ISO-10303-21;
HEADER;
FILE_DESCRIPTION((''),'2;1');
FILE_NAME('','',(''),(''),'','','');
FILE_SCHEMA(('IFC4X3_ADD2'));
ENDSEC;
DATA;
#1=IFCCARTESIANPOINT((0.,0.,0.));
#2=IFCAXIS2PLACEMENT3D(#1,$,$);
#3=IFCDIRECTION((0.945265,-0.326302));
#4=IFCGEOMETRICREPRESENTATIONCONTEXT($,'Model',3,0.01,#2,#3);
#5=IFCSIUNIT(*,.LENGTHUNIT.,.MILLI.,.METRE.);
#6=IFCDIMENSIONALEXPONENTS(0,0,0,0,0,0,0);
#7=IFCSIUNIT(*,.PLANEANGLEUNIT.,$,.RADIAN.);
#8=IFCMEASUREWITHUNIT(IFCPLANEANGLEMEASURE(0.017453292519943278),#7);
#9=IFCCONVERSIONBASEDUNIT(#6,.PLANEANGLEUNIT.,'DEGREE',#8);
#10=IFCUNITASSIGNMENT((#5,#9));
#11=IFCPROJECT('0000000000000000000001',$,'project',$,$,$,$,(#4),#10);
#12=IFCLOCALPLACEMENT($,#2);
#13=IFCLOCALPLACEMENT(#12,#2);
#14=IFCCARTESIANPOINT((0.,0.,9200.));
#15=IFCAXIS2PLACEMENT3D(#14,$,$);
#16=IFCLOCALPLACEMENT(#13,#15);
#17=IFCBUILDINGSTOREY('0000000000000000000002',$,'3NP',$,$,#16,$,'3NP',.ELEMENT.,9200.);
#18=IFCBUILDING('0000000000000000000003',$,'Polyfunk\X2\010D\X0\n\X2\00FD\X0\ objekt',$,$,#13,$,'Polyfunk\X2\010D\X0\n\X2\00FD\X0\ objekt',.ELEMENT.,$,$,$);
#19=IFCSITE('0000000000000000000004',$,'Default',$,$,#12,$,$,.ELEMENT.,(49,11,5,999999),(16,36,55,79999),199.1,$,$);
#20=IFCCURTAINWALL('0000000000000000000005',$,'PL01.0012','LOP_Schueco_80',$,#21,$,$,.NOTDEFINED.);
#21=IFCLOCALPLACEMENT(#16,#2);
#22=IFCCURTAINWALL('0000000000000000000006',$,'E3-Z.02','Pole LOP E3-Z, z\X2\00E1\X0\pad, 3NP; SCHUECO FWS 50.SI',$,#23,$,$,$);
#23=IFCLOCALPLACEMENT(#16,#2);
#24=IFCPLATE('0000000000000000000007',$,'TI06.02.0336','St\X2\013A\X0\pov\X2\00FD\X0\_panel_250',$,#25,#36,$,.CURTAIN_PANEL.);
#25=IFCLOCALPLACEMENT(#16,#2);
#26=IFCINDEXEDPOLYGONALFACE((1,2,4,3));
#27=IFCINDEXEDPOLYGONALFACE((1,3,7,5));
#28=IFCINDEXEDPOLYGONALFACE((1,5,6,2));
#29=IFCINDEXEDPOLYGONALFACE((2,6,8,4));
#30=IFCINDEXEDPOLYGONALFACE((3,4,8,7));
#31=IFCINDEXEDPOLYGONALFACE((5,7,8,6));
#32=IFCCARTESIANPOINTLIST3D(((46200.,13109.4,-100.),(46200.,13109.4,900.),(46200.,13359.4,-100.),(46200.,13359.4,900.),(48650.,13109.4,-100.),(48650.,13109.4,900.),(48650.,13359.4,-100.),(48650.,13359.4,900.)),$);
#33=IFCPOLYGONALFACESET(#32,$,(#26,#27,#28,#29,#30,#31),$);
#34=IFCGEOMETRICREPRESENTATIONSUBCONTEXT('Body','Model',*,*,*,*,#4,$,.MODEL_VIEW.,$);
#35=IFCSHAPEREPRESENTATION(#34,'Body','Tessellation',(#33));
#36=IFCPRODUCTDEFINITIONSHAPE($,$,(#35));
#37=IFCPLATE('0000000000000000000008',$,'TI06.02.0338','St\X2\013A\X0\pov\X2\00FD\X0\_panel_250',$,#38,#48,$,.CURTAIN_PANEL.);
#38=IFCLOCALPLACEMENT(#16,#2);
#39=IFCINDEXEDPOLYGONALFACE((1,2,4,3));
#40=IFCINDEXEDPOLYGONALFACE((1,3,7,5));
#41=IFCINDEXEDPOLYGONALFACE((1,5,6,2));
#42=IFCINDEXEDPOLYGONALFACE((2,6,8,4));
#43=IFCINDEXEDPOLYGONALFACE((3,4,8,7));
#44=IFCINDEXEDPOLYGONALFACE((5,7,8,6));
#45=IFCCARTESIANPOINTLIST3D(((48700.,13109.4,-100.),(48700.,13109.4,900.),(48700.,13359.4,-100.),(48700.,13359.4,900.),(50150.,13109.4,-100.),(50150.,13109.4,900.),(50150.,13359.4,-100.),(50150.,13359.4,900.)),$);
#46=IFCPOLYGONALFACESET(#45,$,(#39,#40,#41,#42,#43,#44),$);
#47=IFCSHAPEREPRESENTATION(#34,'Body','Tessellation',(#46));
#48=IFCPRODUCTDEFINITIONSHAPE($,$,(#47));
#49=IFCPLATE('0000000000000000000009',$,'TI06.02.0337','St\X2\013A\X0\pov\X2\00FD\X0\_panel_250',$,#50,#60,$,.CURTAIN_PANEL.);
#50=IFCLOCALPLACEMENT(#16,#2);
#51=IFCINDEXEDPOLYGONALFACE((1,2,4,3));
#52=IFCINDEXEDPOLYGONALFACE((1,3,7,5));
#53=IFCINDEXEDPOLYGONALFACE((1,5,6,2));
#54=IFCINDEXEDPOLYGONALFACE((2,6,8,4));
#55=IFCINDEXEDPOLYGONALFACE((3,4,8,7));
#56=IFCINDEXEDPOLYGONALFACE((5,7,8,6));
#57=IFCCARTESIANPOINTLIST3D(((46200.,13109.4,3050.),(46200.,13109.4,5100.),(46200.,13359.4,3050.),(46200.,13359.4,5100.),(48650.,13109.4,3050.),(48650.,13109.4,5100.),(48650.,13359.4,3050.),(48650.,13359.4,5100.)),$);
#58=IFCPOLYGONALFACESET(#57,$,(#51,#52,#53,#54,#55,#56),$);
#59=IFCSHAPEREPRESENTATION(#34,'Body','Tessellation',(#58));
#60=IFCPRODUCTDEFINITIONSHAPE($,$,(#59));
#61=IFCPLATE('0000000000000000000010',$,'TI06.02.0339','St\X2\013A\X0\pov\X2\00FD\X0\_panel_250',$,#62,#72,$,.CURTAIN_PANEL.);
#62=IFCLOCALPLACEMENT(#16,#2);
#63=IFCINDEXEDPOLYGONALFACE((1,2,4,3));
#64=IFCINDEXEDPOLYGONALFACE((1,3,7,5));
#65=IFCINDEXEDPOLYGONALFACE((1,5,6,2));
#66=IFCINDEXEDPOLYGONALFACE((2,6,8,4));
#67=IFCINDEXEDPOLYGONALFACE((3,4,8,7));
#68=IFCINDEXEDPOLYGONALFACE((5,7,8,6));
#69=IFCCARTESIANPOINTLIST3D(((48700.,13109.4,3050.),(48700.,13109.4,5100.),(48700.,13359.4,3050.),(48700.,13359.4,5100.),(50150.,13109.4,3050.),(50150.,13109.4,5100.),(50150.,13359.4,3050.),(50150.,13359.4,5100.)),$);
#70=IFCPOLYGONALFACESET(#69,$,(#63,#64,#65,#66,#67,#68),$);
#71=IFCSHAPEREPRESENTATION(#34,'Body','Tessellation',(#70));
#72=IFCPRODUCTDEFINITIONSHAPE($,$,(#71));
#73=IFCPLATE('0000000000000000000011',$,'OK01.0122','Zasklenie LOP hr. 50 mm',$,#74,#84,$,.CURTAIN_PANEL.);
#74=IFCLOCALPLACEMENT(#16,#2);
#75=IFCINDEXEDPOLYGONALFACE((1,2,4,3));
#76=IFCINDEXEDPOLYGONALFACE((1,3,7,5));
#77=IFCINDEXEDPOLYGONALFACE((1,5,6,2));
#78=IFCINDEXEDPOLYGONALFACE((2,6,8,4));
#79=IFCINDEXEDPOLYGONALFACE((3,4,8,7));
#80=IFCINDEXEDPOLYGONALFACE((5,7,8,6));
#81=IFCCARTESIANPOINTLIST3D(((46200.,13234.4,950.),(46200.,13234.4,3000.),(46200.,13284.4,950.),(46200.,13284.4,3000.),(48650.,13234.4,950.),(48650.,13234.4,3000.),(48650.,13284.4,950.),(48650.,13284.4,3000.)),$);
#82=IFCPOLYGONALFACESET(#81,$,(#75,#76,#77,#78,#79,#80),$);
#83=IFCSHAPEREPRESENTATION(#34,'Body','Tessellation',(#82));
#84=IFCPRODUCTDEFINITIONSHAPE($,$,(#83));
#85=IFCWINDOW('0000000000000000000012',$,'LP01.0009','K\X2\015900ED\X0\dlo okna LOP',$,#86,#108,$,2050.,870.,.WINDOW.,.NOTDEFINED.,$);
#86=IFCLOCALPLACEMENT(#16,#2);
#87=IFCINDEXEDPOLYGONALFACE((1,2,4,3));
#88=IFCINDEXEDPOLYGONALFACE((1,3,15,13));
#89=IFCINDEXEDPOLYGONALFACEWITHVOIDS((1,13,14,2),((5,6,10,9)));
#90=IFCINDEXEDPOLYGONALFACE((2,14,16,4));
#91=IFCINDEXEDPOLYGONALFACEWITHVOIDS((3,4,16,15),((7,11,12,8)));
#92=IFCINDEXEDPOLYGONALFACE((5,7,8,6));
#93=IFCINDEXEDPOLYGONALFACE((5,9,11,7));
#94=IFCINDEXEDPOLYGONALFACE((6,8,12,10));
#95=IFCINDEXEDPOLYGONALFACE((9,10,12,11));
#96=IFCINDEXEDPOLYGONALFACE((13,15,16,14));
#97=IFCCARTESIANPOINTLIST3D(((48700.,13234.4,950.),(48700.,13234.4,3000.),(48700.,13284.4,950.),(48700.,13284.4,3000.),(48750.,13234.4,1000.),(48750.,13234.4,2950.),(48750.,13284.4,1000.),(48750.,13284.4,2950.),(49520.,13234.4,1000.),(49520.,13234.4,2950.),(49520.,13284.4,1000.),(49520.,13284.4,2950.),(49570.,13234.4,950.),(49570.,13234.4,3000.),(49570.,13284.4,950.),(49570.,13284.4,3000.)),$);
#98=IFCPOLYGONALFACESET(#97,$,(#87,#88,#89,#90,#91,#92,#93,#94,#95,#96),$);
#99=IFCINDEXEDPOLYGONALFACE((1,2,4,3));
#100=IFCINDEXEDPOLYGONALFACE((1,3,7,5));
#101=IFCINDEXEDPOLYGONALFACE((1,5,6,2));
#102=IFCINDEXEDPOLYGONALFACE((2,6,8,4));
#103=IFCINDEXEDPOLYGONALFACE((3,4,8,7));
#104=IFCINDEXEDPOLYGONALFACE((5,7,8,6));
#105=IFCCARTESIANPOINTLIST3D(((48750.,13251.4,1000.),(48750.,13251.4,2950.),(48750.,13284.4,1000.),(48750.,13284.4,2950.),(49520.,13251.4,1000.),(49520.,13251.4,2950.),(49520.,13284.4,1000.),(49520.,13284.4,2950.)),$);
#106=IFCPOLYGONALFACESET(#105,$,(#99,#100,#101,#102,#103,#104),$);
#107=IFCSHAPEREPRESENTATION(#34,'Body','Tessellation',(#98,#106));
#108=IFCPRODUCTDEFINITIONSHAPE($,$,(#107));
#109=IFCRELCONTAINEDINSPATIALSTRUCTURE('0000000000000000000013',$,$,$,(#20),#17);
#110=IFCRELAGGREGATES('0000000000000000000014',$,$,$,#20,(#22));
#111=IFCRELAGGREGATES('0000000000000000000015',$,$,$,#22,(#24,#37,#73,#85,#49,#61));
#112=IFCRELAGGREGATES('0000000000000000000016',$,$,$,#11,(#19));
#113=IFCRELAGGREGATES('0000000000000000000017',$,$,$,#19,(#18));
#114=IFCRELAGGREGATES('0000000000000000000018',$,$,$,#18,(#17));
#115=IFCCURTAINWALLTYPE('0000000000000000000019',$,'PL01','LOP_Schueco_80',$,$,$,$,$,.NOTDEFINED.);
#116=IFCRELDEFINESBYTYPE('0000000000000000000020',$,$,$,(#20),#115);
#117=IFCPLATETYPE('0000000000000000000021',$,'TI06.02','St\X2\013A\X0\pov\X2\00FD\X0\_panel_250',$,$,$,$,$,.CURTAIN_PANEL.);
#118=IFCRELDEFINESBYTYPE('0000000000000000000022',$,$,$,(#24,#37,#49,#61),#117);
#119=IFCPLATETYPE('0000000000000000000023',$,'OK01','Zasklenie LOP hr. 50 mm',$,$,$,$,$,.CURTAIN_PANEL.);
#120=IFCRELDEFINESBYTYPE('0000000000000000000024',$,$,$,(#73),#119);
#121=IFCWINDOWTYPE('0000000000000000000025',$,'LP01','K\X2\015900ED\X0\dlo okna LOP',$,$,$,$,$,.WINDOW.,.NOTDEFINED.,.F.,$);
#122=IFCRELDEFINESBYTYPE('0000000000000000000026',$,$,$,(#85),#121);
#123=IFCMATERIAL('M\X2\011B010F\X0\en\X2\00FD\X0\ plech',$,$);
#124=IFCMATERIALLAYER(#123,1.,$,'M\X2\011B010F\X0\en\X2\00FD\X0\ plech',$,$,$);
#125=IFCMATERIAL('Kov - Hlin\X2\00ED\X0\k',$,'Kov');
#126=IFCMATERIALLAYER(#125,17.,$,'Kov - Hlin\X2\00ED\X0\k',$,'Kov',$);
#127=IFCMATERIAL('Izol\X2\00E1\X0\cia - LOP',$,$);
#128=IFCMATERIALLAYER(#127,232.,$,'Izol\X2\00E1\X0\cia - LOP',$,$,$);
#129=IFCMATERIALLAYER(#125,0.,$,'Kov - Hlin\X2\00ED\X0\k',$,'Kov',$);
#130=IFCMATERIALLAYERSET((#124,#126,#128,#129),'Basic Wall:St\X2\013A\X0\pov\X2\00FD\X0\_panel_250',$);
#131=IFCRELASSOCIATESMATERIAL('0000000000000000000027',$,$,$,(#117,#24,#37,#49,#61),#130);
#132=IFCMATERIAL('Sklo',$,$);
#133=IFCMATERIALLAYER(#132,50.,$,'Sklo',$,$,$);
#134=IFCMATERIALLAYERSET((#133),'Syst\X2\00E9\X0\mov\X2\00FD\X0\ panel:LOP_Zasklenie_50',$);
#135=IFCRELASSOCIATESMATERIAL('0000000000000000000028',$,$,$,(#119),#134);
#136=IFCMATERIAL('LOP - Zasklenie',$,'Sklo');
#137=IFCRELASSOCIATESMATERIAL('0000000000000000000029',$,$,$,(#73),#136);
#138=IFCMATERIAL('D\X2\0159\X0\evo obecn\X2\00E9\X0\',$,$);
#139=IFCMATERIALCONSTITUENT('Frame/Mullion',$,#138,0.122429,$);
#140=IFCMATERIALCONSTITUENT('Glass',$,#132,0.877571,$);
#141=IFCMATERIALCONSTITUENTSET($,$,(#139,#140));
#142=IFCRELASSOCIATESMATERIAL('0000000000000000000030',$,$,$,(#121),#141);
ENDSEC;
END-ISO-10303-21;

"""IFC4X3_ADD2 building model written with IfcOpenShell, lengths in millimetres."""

from ifc_helpers import new_model, entity, si_unit, converted_unit, direction, frame, frame_2d, origin, origin_2d_with_axis, place, context, subcontext, project, spatial, polyline, rectangle, outline, extrude, source, transform, mapped, material, layer, layer_set, layer_usage, constituent, constituent_set, type_object, type_shapes, element, aggregate, save


model = new_model("IFC4X3_ADD2")

# Units and contexts
model_context = context("Model", 3, precision=0.01, world=origin(), true_north=direction((0.945265, -0.326302)))
body_context = subcontext(model_context, "Body", "Model", "MODEL_VIEW")
ifc_project = project(units=[si_unit("LENGTHUNIT", "METRE", prefix="MILLI"), converted_unit("PLANEANGLEUNIT", "DEGREE", entity("IfcPlaneAngleMeasure", 0.017453292519943278), si_unit("PLANEANGLEUNIT", "RADIAN"), dimensions=[0, 0, 0, 0, 0, 0, 0])], contexts=[model_context])

# Site, building, storey
site_placement = place(None, origin())
site = spatial("IfcSite", under=ifc_project, at=site_placement, Name="Default", CompositionType="ELEMENT", RefLatitude=(49, 11, 5, 999999), RefLongitude=(16, 36, 55, 79999), RefElevation=199.1)
building_placement = place(site_placement, origin())
building = spatial("IfcBuilding", under=site, at=building_placement, Name="Polyfunkčný objekt", LongName="Polyfunkčný objekt", CompositionType="ELEMENT")
storey_placement = place(building_placement, frame((0.0, 0.0, 9200.0)))
storey = spatial("IfcBuildingStorey", under=building, at=storey_placement, Name="3NP", LongName="3NP", CompositionType="ELEMENT", Elevation=9200.0)

# Curtain walls, plates, window
curtain_wall_type = type_object("IfcCurtainWallType", Name="PL01", Description="LOP_Schueco_80", PredefinedType="NOTDEFINED")
curtain_wall_1_placement = place(storey_placement, frame((0.0, 0.0, -9200.0)))
curtain_wall_1 = element("IfcCurtainWall", 1, at=curtain_wall_1_placement, inside=storey, type_object=curtain_wall_type, Name="PL01.0012", Description="LOP_Schueco_80", PredefinedType="NOTDEFINED")
curtain_wall_2 = element("IfcCurtainWall", 2, Name="E3-Z.02", Description="Pole LOP E3-Z, západ, 3NP; SCHUECO FWS 50.SI")
aggregate(curtain_wall_1, [curtain_wall_2])
ifc_material_1 = material(Name="Měďený plech")
ifc_layer_1 = layer(ifc_material_1, 1.0, Name="Měďený plech")
ifc_material_2 = material(Name="Kov - Hliník", Category="Kov")
ifc_layer_2 = layer(ifc_material_2, 17.0, Name="Kov - Hliník", Category="Kov")
ifc_material_3 = material(Name="Izolácia - LOP")
ifc_layer_3 = layer(ifc_material_3, 232.0, Name="Izolácia - LOP")
ifc_layer_4 = layer(ifc_material_2, 0.0, Name="Kov - Hliník", Category="Kov")
ifc_layer_set_1 = layer_set([ifc_layer_1, ifc_layer_2, ifc_layer_3, ifc_layer_4], Name="Basic Wall:Stĺpový_panel_250")
ifc_layer_usage_1 = layer_usage(ifc_layer_set_1, "AXIS2", "NEGATIVE", 125.0)
plate_type_1 = type_object("IfcPlateType", Name="TI06.02", Description="Stĺpový_panel_250", PredefinedType="CURTAIN_PANEL", material=ifc_layer_set_1)
plate_1_placement = place(storey_placement, frame((46200.0, 13234.4, -100.0)))
plate_1 = element("IfcPlate", 3, at=plate_1_placement, type_object=plate_type_1, material=ifc_layer_usage_1, Name="TI06.02.0336", Description="Stĺpový_panel_250", PredefinedType="CURTAIN_PANEL", context=body_context, shape_type="SweptSolid", body=[
    extrude(rectangle(XDim=250.0, YDim=2450.0, at=frame_2d((0.0, 0.0), x_axis=(1.0, 0.0))), frame((1225.0, 0.0, 0.0), z_axis=(0.0, 0.0, 1.0), x_axis=(0.0, 1.0, 0.0)), (0.0, 0.0, 1.0), 1000.0),
])
ifc_layer_usage_2 = layer_usage(ifc_layer_set_1, "AXIS2", "NEGATIVE", 125.0)
plate_2_placement = place(storey_placement, frame((48700.0, 13234.4, -100.0)))
plate_2 = element("IfcPlate", 4, at=plate_2_placement, type_object=plate_type_1, material=ifc_layer_usage_2, Name="TI06.02.0338", Description="Stĺpový_panel_250", PredefinedType="CURTAIN_PANEL", context=body_context, shape_type="SweptSolid", body=[
    extrude(rectangle(XDim=250.0, YDim=1450.0, at=frame_2d((0.0, 0.0), x_axis=(1.0, 0.0))), frame((725.0, 0.0, 0.0), z_axis=(0.0, 0.0, 1.0), x_axis=(0.0, 1.0, 0.0)), (0.0, 0.0, 1.0), 1000.0),
])
ifc_layer_usage_3 = layer_usage(ifc_layer_set_1, "AXIS2", "NEGATIVE", 125.0)
plate_3_placement = place(storey_placement, frame((46200.0, 13234.4, 3050.0)))
plate_3 = element("IfcPlate", 5, at=plate_3_placement, type_object=plate_type_1, material=ifc_layer_usage_3, Name="TI06.02.0337", Description="Stĺpový_panel_250", PredefinedType="CURTAIN_PANEL", context=body_context, shape_type="SweptSolid", body=[
    extrude(rectangle(XDim=250.0, YDim=2450.0, at=frame_2d((0.0, 0.0), x_axis=(1.0, 0.0))), frame((1225.0, 0.0, 0.0), z_axis=(0.0, 0.0, 1.0), x_axis=(0.0, 1.0, 0.0)), (0.0, 0.0, 1.0), 2050.0),
])
ifc_layer_usage_4 = layer_usage(ifc_layer_set_1, "AXIS2", "NEGATIVE", 125.0)
plate_4_placement = place(storey_placement, frame((48700.0, 13234.4, 3050.0)))
plate_4 = element("IfcPlate", 6, at=plate_4_placement, type_object=plate_type_1, material=ifc_layer_usage_4, Name="TI06.02.0339", Description="Stĺpový_panel_250", PredefinedType="CURTAIN_PANEL", context=body_context, shape_type="SweptSolid", body=[
    extrude(rectangle(XDim=250.0, YDim=1450.0, at=frame_2d((0.0, 0.0), x_axis=(1.0, 0.0))), frame((725.0, 0.0, 0.0), z_axis=(0.0, 0.0, 1.0), x_axis=(0.0, 1.0, 0.0)), (0.0, 0.0, 1.0), 2050.0),
])
ifc_material_4 = material(Name="LOP - Zasklenie", Category="Sklo")
ifc_material_5 = material(Name="Sklo")
ifc_layer_5 = layer(ifc_material_5, 50.0, Name="Sklo")
ifc_layer_set_2 = layer_set([ifc_layer_5], Name="Systémový panel:LOP_Zasklenie_50")
plate_type_2 = type_object("IfcPlateType", Name="OK01", Description="Zasklenie LOP hr. 50 mm", PredefinedType="CURTAIN_PANEL", material=ifc_layer_set_2)
shared_shape_1 = source(origin(), body_context, "Body", "SweptSolid", [
    extrude(rectangle(XDim=50.0, YDim=2450.0, at=origin_2d_with_axis()), frame((0.0, 25.0, 0.0), z_axis=(0.0, 0.0, 1.0), x_axis=(0.0, 1.0, 0.0)), (0.0, 0.0, 1.0), 2050.0),
])
type_shapes(plate_type_2, [shared_shape_1])
plate_5_placement = place(curtain_wall_1_placement, frame((47425.0, 13234.4, 10150.0)))
plate_5 = element("IfcPlate", 7, at=plate_5_placement, type_object=plate_type_2, material=ifc_material_4, Name="OK01.0122", Description="Zasklenie LOP hr. 50 mm", PredefinedType="CURTAIN_PANEL", context=body_context, shape_type="MappedRepresentation", body=[
    mapped(shared_shape_1, transform((0.0, 0.0, 0.0), scale=1.0)),
])
ifc_material_6 = material(Name="Dřevo obecné")
ifc_constituent_1 = constituent(ifc_material_6, Name="Frame/Mullion", fraction=0.122429)
ifc_constituent_2 = constituent(ifc_material_5, Name="Glass", fraction=0.877571)
ifc_constituent_set = constituent_set(constituents=[ifc_constituent_1, ifc_constituent_2])
window_type = type_object("IfcWindowType", Name="LP01", Description="Křídlo okna LOP", ParameterTakesPrecedence=False, PartitioningType="NOTDEFINED", PredefinedType="WINDOW", material=ifc_constituent_set)
shared_shape_2 = source(origin(), body_context, "Body", "SweptSolid", [
    extrude(outline(polyline([(-1025.0, -435.0), (1025.0, -435.0), (1025.0, 435.0), (-1025.0, 435.0), (-1025.0, -435.0)]), holes=[polyline([(-975.0, -385.0), (-975.0, 385.0), (975.0, 385.0), (975.0, -385.0), (-975.0, -385.0)])]), frame((0.0, 0.0, 1025.0), z_axis=(0.0, 1.0, 0.0), x_axis=(0.0, 0.0, -1.0)), (0.0, 0.0, 1.0), 50.0),
    extrude(rectangle(XDim=33.0, YDim=770.0, at=origin_2d_with_axis()), frame((0.0, 33.5, 50.0), z_axis=(0.0, 0.0, 1.0), x_axis=(0.0, -1.0, 0.0)), (0.0, 0.0, 1.0), 1950.0),
])
type_shapes(window_type, [shared_shape_2])
window_placement = place(curtain_wall_1_placement, frame((49135.0, 13234.4, 10150.0)))
window = element("IfcWindow", 8, at=window_placement, type_object=window_type, Name="LP01.0009", Description="Křídlo okna LOP", OverallHeight=2050.0, OverallWidth=870.0, PartitioningType="NOTDEFINED", PredefinedType="WINDOW", context=body_context, shape_type="MappedRepresentation", body=[
    mapped(shared_shape_2, transform((0.0, 0.0, 0.0), scale=1.0)),
])
aggregate(curtain_wall_2, [plate_1, plate_2, plate_5, window, plate_3, plate_4])

save(model, "model.ifc")
